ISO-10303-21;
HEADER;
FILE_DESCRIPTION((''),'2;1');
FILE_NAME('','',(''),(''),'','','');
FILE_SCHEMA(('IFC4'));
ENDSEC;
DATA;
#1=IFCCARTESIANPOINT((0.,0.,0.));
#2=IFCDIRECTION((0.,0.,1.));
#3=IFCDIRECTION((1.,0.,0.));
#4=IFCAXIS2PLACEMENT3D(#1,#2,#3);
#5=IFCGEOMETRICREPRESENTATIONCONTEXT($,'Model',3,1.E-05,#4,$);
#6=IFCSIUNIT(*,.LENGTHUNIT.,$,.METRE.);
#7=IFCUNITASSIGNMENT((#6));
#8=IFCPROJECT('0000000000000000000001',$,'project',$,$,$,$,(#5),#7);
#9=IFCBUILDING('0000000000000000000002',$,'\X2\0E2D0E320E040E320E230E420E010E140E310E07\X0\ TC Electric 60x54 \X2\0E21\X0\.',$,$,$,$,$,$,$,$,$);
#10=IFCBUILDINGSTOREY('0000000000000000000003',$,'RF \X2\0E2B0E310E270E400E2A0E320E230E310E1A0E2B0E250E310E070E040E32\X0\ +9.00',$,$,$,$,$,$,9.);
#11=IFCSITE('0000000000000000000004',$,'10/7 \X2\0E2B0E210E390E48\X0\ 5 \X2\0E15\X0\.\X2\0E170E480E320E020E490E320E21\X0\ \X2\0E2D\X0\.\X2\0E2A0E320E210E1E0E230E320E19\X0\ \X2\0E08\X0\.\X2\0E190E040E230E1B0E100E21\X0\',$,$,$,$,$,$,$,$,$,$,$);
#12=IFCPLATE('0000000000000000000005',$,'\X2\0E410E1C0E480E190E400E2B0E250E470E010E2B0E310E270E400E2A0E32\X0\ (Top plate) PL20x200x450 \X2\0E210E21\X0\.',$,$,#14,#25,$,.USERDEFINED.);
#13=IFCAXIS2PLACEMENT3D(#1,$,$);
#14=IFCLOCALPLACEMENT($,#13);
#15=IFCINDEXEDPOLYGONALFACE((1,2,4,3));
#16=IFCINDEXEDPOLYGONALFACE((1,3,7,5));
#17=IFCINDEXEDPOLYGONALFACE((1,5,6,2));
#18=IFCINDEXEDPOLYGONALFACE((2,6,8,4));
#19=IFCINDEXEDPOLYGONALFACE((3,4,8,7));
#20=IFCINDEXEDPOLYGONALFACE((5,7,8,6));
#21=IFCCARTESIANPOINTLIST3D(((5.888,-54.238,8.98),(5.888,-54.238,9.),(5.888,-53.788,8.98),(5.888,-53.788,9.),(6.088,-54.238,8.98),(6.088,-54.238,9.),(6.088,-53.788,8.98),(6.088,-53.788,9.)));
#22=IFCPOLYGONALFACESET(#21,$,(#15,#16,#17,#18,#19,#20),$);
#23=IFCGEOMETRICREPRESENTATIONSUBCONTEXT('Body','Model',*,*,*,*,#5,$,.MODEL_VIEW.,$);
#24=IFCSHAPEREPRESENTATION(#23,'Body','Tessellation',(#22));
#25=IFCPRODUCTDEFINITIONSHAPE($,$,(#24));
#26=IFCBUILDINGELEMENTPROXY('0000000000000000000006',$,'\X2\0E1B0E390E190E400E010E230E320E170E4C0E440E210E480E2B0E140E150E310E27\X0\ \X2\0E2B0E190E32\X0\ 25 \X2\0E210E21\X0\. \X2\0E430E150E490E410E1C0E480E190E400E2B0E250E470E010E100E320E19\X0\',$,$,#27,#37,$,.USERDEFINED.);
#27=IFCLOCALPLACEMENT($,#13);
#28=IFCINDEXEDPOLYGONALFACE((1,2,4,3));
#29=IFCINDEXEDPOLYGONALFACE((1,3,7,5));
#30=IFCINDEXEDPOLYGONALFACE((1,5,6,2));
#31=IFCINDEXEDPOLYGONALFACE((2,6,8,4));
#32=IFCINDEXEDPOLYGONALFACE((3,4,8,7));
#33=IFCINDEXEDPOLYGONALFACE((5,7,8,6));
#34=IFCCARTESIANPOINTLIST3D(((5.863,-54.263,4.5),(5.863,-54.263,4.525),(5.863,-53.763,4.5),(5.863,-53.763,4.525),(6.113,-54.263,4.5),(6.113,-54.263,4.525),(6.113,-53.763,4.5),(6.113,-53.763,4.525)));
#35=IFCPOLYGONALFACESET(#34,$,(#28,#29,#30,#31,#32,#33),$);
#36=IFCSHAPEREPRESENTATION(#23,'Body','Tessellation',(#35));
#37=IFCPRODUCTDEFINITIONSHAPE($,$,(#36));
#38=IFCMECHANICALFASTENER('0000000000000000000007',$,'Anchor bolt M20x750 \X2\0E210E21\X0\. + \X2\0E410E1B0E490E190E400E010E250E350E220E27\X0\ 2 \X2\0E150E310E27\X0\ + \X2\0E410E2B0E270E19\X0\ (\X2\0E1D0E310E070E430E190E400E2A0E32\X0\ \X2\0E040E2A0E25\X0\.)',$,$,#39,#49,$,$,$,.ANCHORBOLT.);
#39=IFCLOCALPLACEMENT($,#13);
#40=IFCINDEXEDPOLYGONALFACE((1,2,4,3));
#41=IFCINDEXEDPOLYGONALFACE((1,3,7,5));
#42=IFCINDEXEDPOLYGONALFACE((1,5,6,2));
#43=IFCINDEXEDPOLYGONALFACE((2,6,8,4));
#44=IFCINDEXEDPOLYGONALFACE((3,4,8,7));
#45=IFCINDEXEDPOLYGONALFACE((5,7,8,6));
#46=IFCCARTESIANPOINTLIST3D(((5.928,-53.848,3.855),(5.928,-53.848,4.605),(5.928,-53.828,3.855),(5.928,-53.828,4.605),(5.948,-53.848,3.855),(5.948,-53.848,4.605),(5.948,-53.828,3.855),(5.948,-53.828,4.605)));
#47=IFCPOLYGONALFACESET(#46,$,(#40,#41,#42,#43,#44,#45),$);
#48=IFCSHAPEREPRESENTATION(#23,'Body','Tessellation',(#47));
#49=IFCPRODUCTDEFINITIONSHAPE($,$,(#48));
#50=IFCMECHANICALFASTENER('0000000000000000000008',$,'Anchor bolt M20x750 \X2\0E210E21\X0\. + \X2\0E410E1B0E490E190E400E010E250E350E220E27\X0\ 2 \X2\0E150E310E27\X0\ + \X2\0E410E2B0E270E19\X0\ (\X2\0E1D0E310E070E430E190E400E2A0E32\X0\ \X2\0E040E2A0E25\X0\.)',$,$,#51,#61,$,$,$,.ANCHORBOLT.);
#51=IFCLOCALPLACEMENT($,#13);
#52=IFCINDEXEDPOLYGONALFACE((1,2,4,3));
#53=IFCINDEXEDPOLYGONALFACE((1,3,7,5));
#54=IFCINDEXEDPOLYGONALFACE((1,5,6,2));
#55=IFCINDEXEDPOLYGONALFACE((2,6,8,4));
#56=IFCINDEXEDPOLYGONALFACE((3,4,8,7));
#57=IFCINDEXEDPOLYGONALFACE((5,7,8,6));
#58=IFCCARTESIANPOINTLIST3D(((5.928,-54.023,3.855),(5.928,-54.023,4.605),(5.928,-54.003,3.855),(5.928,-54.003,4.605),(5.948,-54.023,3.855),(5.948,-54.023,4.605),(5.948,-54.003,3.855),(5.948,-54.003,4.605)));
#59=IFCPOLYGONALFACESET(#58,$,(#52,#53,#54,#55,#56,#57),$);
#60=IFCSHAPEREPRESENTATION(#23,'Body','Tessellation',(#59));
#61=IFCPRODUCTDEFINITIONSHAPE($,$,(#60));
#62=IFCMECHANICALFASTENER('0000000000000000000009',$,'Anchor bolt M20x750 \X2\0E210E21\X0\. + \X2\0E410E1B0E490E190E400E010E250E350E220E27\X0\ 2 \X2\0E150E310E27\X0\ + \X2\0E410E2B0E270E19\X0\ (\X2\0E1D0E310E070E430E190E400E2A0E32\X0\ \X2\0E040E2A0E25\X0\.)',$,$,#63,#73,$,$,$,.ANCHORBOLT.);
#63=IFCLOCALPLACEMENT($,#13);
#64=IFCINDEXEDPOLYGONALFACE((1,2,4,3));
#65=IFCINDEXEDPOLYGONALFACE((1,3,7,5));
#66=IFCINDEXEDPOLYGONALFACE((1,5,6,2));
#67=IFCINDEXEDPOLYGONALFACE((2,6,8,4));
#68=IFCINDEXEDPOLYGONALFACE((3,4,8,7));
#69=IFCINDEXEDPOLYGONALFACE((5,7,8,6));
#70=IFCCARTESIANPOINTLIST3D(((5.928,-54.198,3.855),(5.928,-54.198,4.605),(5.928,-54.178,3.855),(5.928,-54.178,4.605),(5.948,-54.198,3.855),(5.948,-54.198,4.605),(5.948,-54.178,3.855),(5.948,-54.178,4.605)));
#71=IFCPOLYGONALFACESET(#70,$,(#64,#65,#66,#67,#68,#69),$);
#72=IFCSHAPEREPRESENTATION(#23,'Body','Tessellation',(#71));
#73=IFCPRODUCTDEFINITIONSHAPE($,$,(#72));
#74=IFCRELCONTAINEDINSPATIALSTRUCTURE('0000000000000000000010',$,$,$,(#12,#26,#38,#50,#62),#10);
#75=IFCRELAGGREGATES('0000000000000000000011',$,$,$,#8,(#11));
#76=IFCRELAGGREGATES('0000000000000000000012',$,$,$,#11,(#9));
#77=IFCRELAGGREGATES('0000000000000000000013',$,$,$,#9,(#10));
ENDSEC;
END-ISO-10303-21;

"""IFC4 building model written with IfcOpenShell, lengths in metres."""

from ifc_helpers import new_model, si_unit, frame, origin, origin_with_axes, origin_2d, place, context, subcontext, project, spatial, rectangle, extrude, element, save


model = new_model("IFC4")

# Units and contexts
model_context = context("Model", 3, precision=1e-05, world=origin_with_axes())
body_context = subcontext(model_context, "Body", "Model", "MODEL_VIEW")
ifc_project = project(units=[si_unit("LENGTHUNIT", "METRE")], contexts=[model_context])

# Site, building, storey
site = spatial("IfcSite", under=ifc_project, Name="10/7 หมู่ 5 ต.ท่าข้าม อ.สามพราน จ.นครปฐม")
building = spatial("IfcBuilding", under=site, Name="อาคารโกดัง TC Electric 60x54 ม.")
storey = spatial("IfcBuildingStorey", under=building, Name="RF หัวเสารับหลังคา +9.00", Elevation=9.0)

# Plate
for number, where, z_axis, x_axis, name in (
    (1, (5.988, -54.013, 8.98), (0.0, 0.0, 1.0), (1.0, 0.0, 0.0), "แผ่นเหล็กหัวเสา (Top plate) PL20x200x450 มม."),
):
    element("IfcPlate", number, at=place(None, frame(where, z_axis=z_axis, x_axis=x_axis)), inside=storey, Name=name, PredefinedType="USERDEFINED", context=body_context, shape_type="SweptSolid", body=[
        extrude(rectangle(XDim=0.2, YDim=0.45, at=origin_2d()), origin(), (0.0, 0.0, 1.0), 0.02),
    ])

# Building element proxy
proxy_placement = place(None, frame((5.988, -54.013, 4.5), z_axis=(0.0, 0.0, 1.0), x_axis=(1.0, 0.0, 0.0)))
element("IfcBuildingElementProxy", 2, at=proxy_placement, inside=storey, Name="ปูนเกราท์ไม่หดตัว หนา 25 มม. ใต้แผ่นเหล็กฐาน", PredefinedType="USERDEFINED", context=body_context, shape_type="SweptSolid", body=[
    extrude(rectangle(XDim=0.25, YDim=0.5, at=origin_2d()), origin(), (0.0, 0.0, 1.0), 0.025),
])

# Mechanical fasteners
for number, where, z_axis, x_axis, name in (
    (3, (5.938, -53.838, 3.855), (0.0, 0.0, 1.0), (1.0, 0.0, 0.0), "Anchor bolt M20x750 มม. + แป้นเกลียว 2 ตัว + แหวน (ฝังในเสา คสล.)"),
    (4, (5.938, -54.013, 3.855), (0.0, 0.0, 1.0), (1.0, 0.0, 0.0), "Anchor bolt M20x750 มม. + แป้นเกลียว 2 ตัว + แหวน (ฝังในเสา คสล.)"),
    (5, (5.938, -54.188, 3.855), (0.0, 0.0, 1.0), (1.0, 0.0, 0.0), "Anchor bolt M20x750 มม. + แป้นเกลียว 2 ตัว + แหวน (ฝังในเสา คสล.)"),
):
    element("IfcMechanicalFastener", number, at=place(None, frame(where, z_axis=z_axis, x_axis=x_axis)), inside=storey, Name=name, PredefinedType="ANCHORBOLT", context=body_context, shape_type="SweptSolid", body=[
        extrude(rectangle(XDim=0.02, YDim=0.02, at=origin_2d()), origin(), (0.0, 0.0, 1.0), 0.75),
    ])

save(model, "model.ifc")
